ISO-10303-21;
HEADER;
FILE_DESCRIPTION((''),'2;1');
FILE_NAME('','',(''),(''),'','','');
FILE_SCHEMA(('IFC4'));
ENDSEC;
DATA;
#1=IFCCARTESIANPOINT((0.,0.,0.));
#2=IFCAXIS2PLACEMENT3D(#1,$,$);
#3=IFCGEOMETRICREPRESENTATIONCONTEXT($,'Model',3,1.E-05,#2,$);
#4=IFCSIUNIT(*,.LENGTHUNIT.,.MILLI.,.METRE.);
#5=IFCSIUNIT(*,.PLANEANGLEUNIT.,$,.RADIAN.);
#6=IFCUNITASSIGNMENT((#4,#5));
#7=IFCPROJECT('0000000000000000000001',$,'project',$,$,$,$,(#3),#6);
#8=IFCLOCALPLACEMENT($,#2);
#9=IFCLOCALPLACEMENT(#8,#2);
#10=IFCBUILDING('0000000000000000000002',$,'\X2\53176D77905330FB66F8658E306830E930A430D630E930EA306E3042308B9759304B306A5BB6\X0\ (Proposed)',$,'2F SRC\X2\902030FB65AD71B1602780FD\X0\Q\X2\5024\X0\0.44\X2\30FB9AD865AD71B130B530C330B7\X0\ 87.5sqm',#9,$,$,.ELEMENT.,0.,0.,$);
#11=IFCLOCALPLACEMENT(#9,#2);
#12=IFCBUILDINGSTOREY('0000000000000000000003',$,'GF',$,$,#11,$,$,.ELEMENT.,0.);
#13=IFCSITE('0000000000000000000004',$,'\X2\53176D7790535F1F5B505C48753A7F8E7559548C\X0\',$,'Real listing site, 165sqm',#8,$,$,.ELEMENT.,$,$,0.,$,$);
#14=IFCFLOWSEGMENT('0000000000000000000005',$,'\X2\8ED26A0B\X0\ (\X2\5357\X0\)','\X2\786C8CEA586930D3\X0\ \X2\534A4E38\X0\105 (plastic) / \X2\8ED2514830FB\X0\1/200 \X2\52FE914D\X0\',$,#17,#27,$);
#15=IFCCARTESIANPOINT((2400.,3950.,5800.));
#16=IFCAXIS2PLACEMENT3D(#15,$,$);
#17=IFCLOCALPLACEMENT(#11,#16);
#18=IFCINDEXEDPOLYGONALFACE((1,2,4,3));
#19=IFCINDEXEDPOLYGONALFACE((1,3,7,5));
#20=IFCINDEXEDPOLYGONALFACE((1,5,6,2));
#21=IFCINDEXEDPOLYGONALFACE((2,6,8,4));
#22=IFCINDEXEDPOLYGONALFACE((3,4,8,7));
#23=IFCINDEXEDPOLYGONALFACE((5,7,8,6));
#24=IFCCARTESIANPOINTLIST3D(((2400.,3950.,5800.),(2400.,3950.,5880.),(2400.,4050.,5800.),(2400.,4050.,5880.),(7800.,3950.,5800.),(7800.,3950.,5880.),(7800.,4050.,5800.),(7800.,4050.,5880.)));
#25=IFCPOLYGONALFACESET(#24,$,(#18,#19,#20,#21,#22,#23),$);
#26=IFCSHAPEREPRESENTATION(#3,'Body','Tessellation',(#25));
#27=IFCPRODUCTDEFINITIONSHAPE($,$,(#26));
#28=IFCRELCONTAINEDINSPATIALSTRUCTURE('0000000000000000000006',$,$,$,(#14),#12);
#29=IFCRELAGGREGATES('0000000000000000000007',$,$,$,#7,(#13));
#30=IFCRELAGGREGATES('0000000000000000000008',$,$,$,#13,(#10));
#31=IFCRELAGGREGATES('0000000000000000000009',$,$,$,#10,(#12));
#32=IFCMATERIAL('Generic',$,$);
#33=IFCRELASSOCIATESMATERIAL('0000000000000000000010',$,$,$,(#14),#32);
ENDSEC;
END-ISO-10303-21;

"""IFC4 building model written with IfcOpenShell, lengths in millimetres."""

from ifc_helpers import new_model, si_unit, frame, frame_2d, origin, place, context, project, spatial, rectangle, extrude, material, element, save


model = new_model("IFC4")

# Units and contexts
model_context = context("Model", 3, precision=1e-05, world=origin())
ifc_project = project(units=[si_unit("LENGTHUNIT", "METRE", prefix="MILLI"), si_unit("PLANEANGLEUNIT", "RADIAN")], contexts=[model_context])

# Site, building, storey
site_placement = place(None, origin())
site = spatial("IfcSite", under=ifc_project, at=site_placement, Name="北海道弟子屈町美留和", ObjectType="Real listing site, 165sqm", CompositionType="ELEMENT", RefElevation=0.0)
building_placement = place(site_placement, origin())
building = spatial("IfcBuilding", under=site, at=building_placement, Name="北海道・書斎とライブラリのある静かな家 (Proposed)", ObjectType="2F SRC造・断熱性能Q値0.44・高断熱サッシ 87.5sqm", CompositionType="ELEMENT", ElevationOfRefHeight=0.0, ElevationOfTerrain=0.0)
storey_placement = place(building_placement, origin())
storey = spatial("IfcBuildingStorey", under=building, at=storey_placement, Name="GF", CompositionType="ELEMENT", Elevation=0.0)

# Flow segment
ifc_material_1 = material(Name="Generic")
flow_segment_placement = place(storey_placement, frame((2400.0, 3950.0, 5800.0)))
element("IfcFlowSegment", 1, at=flow_segment_placement, inside=storey, material=ifc_material_1, Name="軒樋 (南)", Description="硬質塩ビ 半丸105 (plastic) / 軒先・1/200 勾配", context=model_context, shape_type="SweptSolid", body=[
    extrude(rectangle(XDim=5400.0, YDim=100.0, at=frame_2d((2700.0, 50.0))), frame((2400.0, 3950.0, 5800.0)), (0.0, 0.0, 1.0), 80.0),
])

save(model, "model.ifc")
